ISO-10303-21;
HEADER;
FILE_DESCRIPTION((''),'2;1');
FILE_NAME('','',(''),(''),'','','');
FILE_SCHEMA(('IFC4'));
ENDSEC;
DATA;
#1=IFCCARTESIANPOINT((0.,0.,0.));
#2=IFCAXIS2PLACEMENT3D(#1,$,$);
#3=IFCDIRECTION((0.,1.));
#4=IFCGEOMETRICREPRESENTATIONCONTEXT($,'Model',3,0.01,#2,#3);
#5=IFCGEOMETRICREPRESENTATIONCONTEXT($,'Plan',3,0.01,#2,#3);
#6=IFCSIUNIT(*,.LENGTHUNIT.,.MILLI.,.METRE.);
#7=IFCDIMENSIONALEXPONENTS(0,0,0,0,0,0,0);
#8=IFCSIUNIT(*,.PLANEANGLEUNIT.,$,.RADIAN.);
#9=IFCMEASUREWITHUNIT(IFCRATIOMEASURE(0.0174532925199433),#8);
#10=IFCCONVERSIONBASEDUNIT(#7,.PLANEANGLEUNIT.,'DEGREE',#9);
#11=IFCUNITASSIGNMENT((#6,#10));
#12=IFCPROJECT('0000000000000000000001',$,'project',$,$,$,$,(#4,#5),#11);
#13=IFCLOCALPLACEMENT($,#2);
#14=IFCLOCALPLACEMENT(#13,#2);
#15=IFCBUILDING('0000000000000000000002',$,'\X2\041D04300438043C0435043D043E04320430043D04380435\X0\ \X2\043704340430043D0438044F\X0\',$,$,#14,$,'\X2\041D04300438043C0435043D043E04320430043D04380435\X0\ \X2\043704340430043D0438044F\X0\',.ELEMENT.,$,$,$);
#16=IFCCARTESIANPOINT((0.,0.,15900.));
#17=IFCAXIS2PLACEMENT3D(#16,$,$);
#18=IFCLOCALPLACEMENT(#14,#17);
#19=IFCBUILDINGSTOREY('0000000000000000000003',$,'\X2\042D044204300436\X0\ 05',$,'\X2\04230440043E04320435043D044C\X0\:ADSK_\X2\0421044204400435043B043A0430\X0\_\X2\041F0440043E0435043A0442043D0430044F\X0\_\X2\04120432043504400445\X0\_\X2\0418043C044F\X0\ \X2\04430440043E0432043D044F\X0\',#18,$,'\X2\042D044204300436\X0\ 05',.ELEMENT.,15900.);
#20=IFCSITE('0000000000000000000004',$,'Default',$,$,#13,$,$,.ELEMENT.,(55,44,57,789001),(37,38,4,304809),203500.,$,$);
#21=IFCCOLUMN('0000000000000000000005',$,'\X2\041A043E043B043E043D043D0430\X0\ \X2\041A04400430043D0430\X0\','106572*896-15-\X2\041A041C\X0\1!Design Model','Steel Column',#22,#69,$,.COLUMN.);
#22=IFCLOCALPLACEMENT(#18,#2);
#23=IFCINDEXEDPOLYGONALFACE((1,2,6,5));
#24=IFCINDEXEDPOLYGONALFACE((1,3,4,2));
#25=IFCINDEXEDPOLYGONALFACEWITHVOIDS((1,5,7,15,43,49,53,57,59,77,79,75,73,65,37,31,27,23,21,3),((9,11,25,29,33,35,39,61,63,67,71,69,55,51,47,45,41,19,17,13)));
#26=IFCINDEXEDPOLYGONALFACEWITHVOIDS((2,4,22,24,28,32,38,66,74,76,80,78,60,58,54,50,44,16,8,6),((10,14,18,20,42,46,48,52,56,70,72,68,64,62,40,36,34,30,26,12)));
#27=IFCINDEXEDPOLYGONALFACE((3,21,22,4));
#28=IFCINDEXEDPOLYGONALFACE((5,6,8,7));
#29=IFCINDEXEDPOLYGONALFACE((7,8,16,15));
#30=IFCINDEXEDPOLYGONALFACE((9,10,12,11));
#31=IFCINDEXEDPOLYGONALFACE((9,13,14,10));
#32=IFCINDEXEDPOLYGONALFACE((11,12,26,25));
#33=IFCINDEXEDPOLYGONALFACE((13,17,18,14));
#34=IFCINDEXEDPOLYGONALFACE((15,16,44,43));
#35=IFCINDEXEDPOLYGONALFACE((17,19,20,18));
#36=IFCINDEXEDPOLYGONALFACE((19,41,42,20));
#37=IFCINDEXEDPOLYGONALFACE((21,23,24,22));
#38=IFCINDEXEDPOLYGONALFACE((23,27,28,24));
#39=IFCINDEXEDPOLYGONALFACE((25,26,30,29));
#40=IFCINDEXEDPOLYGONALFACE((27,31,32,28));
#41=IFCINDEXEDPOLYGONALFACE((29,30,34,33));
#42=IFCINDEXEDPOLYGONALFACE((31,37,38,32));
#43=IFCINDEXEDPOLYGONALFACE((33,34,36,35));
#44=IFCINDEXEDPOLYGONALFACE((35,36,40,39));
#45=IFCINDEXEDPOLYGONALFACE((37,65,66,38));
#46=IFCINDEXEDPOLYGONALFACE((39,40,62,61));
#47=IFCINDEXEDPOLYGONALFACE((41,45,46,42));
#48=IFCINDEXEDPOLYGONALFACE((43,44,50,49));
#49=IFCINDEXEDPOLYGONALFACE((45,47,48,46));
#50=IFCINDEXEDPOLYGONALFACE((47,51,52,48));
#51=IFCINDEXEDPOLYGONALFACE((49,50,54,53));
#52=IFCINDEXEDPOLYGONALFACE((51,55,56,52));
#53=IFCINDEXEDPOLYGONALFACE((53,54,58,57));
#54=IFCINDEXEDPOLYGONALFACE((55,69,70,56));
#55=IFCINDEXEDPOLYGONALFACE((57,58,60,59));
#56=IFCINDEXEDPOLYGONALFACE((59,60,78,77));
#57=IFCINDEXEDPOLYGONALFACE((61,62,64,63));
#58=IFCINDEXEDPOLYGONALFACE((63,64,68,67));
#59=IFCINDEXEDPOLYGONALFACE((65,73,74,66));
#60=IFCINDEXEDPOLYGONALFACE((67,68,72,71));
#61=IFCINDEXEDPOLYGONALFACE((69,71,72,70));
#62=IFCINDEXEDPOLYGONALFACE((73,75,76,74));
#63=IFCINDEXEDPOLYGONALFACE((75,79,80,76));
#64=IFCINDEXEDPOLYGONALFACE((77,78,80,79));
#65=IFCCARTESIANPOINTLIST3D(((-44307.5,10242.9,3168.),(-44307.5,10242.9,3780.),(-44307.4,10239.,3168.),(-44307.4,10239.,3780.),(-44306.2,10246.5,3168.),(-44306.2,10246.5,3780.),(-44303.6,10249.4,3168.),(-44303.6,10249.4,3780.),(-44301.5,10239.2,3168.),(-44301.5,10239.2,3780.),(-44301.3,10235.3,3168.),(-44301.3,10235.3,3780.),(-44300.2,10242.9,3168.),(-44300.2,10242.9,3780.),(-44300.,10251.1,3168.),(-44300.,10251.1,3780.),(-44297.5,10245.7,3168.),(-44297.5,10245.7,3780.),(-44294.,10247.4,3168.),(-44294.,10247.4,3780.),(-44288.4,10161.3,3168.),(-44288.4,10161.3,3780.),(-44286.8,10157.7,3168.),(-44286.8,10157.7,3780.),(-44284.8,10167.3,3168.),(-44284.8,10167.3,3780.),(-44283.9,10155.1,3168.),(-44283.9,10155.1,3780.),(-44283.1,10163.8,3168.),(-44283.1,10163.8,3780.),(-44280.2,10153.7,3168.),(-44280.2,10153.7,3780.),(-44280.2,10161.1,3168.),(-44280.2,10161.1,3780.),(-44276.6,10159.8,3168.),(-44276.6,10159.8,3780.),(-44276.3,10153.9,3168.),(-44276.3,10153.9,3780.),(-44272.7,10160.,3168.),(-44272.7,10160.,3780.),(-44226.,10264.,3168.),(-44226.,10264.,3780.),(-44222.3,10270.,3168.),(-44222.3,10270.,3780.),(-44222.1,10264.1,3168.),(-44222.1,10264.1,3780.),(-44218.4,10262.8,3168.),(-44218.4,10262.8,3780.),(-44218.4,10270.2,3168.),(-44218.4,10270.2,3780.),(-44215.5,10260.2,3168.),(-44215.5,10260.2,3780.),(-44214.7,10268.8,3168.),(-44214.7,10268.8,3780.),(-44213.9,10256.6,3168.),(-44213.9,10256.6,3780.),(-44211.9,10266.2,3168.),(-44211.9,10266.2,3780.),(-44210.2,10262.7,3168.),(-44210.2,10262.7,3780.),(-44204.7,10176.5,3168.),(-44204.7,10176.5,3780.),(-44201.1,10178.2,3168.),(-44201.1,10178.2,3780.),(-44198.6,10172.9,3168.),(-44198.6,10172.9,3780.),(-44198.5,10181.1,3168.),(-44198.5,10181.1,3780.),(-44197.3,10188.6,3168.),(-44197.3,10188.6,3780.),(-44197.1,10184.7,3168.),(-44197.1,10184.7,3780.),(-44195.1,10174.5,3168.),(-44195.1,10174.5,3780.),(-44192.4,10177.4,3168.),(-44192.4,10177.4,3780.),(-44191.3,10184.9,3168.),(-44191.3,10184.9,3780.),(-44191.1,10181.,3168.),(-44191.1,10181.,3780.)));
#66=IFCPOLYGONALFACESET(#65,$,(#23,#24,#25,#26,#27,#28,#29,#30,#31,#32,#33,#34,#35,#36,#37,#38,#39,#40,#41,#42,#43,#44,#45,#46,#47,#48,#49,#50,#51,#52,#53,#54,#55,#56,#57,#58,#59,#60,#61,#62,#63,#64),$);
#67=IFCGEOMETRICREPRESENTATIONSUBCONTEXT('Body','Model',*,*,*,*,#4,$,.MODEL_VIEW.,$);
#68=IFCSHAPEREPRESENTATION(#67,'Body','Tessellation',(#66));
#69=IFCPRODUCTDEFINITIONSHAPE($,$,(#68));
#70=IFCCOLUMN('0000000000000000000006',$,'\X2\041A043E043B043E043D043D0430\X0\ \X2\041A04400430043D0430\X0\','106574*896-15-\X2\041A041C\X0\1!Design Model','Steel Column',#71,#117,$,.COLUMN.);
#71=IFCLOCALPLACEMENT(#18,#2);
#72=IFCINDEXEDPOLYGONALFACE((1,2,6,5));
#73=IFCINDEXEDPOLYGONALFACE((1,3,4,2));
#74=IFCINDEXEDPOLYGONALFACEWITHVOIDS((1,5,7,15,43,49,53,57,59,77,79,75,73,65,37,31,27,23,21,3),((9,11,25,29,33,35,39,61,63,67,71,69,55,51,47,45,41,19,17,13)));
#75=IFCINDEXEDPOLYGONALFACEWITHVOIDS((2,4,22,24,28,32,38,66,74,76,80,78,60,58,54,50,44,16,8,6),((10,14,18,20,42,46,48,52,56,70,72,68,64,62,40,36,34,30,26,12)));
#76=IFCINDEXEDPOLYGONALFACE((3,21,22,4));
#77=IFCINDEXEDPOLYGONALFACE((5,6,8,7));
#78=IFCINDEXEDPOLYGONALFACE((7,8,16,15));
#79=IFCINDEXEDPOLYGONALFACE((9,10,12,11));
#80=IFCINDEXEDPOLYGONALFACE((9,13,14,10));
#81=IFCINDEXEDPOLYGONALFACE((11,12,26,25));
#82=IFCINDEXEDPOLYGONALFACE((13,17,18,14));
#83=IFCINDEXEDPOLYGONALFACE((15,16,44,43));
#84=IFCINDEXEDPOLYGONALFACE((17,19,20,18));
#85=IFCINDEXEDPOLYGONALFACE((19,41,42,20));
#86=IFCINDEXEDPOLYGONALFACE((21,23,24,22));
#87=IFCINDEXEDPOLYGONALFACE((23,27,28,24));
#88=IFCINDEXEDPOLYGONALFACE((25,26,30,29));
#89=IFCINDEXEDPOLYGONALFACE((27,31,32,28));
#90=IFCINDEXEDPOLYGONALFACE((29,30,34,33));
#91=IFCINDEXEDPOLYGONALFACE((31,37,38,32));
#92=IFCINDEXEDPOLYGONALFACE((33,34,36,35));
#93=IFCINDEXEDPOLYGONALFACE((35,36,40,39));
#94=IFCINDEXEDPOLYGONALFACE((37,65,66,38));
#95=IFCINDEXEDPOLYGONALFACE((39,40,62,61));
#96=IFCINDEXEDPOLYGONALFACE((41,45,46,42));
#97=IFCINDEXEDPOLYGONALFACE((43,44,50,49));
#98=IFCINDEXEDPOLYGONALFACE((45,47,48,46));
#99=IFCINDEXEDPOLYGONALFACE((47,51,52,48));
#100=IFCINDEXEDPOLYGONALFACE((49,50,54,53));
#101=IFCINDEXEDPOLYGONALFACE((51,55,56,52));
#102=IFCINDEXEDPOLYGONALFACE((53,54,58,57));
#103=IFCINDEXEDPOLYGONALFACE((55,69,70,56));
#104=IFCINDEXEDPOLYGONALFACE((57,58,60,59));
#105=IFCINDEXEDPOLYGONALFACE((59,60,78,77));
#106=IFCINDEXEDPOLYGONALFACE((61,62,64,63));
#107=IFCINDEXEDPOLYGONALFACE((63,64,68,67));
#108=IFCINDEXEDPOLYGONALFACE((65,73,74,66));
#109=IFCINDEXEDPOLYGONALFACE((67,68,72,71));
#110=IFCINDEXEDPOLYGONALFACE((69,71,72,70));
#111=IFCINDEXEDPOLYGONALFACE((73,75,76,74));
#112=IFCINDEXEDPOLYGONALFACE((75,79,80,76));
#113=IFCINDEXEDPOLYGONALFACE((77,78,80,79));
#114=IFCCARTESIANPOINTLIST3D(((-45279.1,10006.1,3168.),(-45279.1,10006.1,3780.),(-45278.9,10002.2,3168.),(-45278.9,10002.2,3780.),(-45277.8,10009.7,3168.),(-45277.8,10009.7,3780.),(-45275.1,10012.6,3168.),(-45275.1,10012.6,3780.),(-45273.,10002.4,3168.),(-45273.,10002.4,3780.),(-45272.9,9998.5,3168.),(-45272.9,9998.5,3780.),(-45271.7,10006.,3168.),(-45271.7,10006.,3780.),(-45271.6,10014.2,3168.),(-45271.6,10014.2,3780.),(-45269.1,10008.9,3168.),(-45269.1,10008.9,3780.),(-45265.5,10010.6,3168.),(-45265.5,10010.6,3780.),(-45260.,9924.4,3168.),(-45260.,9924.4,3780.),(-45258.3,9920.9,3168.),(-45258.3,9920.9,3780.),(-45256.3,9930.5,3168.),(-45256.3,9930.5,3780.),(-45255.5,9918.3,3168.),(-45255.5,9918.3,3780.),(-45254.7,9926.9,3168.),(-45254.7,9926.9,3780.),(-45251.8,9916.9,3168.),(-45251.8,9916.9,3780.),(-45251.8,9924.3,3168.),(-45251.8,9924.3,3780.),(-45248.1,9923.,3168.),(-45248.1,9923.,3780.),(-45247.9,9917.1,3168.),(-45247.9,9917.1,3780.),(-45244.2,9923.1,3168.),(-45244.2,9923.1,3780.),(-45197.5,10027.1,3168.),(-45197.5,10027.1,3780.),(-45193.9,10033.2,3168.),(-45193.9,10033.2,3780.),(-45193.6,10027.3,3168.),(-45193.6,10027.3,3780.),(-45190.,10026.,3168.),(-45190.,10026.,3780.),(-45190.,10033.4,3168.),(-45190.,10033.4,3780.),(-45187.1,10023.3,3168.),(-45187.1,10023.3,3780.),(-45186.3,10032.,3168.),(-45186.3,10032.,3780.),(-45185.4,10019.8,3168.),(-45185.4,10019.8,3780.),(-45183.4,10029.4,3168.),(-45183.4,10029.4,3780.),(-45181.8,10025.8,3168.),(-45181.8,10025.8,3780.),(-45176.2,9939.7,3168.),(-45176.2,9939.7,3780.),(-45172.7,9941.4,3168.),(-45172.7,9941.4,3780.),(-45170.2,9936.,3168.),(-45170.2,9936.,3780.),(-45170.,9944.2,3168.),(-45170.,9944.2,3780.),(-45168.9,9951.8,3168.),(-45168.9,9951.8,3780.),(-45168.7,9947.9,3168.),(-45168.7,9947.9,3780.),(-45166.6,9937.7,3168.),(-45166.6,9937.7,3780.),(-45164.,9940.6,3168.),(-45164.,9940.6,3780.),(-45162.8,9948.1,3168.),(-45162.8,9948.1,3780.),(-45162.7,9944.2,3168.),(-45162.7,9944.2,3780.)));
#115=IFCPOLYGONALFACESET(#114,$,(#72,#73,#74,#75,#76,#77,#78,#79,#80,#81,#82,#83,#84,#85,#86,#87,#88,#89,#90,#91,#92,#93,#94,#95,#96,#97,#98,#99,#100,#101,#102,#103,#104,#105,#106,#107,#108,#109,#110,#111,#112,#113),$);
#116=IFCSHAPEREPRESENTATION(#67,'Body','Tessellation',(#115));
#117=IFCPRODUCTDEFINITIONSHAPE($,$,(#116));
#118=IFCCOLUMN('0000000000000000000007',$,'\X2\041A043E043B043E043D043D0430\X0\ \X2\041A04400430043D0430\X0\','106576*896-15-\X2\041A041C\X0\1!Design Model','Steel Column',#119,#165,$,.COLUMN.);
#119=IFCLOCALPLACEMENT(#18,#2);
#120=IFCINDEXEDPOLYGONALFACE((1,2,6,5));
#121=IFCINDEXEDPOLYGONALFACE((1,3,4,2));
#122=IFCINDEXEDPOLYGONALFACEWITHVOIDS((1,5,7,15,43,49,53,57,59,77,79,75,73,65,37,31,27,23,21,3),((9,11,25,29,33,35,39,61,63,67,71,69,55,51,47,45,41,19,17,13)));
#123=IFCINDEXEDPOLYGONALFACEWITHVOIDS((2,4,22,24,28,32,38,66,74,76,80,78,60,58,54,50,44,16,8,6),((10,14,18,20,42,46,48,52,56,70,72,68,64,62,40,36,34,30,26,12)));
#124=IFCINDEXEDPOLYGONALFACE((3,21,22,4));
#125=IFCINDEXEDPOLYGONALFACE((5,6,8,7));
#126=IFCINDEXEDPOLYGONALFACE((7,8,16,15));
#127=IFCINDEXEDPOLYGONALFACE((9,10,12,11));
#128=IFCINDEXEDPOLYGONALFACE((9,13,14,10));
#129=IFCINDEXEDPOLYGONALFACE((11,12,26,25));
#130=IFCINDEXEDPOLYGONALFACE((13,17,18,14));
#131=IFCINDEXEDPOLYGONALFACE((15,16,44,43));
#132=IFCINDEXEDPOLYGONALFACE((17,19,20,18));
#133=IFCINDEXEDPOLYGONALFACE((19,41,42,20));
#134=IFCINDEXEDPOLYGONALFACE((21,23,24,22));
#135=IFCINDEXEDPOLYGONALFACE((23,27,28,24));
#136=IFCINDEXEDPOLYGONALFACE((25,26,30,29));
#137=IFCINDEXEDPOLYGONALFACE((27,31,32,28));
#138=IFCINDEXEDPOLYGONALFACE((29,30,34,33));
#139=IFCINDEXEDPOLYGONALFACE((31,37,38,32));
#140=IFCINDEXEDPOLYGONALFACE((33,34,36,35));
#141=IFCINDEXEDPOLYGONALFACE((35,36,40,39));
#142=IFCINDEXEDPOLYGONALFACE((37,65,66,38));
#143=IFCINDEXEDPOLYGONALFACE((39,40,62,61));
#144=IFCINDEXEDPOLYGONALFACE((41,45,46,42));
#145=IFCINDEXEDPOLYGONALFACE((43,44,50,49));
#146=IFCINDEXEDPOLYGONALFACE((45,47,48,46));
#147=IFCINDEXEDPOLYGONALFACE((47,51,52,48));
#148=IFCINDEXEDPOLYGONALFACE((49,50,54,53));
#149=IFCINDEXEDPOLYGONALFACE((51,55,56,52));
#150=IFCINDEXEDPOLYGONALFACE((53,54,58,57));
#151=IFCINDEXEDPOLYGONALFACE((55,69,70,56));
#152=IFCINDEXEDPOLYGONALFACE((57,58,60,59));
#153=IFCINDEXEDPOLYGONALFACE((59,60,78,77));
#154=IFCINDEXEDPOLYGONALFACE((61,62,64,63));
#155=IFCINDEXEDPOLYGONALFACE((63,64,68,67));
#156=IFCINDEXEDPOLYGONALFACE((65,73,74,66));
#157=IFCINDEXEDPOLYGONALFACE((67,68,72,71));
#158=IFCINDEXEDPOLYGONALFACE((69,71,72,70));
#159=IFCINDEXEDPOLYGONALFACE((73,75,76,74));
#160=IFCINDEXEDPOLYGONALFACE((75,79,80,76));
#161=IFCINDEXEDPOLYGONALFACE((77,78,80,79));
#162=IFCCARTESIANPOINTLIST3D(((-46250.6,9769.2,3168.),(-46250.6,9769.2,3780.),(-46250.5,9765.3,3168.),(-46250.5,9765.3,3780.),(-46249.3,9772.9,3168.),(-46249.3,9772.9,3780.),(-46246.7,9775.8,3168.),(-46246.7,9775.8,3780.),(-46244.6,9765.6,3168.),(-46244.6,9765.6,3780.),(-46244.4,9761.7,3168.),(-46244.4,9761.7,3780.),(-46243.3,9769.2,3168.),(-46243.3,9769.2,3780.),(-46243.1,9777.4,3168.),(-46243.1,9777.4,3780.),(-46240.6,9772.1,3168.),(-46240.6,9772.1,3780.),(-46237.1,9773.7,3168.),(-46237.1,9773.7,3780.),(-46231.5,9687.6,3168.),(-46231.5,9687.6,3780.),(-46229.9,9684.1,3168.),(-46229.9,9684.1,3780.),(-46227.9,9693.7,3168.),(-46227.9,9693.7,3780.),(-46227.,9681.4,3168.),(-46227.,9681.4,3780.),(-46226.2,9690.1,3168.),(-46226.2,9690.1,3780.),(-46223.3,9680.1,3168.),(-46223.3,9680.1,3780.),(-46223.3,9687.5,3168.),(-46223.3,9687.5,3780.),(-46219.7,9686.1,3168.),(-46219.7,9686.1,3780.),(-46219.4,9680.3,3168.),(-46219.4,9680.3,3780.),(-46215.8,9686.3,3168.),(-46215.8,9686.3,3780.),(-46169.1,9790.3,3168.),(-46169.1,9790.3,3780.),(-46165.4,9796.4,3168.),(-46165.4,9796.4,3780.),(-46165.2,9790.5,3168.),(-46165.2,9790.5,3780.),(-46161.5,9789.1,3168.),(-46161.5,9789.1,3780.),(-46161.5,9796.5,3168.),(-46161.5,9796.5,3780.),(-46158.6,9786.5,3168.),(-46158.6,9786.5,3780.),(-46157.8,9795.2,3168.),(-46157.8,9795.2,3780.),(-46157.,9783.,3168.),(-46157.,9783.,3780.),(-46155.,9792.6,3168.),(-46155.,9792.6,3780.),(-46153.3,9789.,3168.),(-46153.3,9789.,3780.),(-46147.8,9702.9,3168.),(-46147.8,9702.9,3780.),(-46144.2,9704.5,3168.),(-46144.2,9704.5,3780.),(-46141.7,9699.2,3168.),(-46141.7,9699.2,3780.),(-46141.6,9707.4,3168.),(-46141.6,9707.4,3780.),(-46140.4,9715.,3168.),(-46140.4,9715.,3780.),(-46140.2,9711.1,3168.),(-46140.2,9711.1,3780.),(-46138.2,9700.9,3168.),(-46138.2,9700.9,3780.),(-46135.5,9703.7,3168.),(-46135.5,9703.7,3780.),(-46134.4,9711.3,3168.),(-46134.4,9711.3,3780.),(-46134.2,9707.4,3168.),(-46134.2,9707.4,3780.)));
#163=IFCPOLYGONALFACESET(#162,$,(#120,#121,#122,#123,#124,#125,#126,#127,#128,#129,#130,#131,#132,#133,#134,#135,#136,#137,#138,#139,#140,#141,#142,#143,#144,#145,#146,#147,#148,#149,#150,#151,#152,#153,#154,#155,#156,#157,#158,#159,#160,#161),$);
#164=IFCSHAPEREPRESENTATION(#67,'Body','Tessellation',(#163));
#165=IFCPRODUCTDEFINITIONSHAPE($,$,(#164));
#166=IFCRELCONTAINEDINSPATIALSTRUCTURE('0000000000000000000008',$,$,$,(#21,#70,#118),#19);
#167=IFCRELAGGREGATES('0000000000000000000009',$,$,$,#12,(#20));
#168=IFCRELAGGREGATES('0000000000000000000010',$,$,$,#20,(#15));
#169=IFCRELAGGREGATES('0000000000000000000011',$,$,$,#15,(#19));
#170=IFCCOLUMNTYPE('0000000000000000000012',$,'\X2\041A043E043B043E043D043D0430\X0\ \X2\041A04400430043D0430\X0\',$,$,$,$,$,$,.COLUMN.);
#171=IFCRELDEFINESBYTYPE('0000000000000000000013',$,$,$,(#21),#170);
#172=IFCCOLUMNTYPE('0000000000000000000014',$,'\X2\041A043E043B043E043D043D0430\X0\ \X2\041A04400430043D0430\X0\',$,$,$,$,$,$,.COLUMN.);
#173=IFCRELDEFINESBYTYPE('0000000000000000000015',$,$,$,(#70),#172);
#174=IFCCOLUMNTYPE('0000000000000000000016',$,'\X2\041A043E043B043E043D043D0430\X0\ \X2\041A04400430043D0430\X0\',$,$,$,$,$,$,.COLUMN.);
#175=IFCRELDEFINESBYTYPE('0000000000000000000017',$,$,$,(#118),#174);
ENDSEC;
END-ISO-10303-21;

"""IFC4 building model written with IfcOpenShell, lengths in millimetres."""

from ifc_helpers import new_model, entity, si_unit, converted_unit, direction, frame, origin, place, context, subcontext, project, spatial, indexed_curve, outline, extrude, type_object, element, save


model = new_model("IFC4")

# Units and contexts
model_context = context("Model", 3, precision=0.01, world=origin(), true_north=direction((0.0, 1.0)))
plan_context = context("Plan", 3, precision=0.01, world=origin(), true_north=direction((0.0, 1.0)))
body_context = subcontext(model_context, "Body", "Model", "MODEL_VIEW")
ifc_project = project(units=[si_unit("LENGTHUNIT", "METRE", prefix="MILLI"), converted_unit("PLANEANGLEUNIT", "DEGREE", entity("IfcRatioMeasure", 0.0174532925199433), si_unit("PLANEANGLEUNIT", "RADIAN"), dimensions=[0, 0, 0, 0, 0, 0, 0])], contexts=[model_context, plan_context])

# Site, building, storey
site_placement = place(None, origin())
site = spatial("IfcSite", under=ifc_project, at=site_placement, Name="Default", CompositionType="ELEMENT", RefLatitude=(55, 44, 57, 789001), RefLongitude=(37, 38, 4, 304809), RefElevation=203500.0)
building_placement = place(site_placement, origin())
building = spatial("IfcBuilding", under=site, at=building_placement, Name="Наименование здания", LongName="Наименование здания", CompositionType="ELEMENT")
storey_placement = place(building_placement, frame((0.0, 0.0, 15900.0)))
storey = spatial("IfcBuildingStorey", under=building, at=storey_placement, Name="Этаж 05", ObjectType="Уровень:ADSK_Стрелка_Проектная_Вверх_Имя уровня", LongName="Этаж 05", CompositionType="ELEMENT", Elevation=15900.0)

# Columns
column_type_1 = type_object("IfcColumnType", Name="Колонна Крана", PredefinedType="COLUMN")
column_1_placement = place(storey_placement, origin())
element("IfcColumn", 1, at=column_1_placement, inside=storey, type_object=column_type_1, Name="Колонна Крана", Description="106572*896-15-КМ1!Design Model", ObjectType="Steel Column", PredefinedType="COLUMN", context=body_context, shape_type="SweptSolid", body=[
    extrude(outline(indexed_curve([(29.5, -56.8), (33.4, -56.8), (37.0, -55.3), (39.7, -52.6), (41.2, -49.0), (56.8, 29.5), (56.8, 33.4), (55.3, 37.0), (52.6, 39.7), (49.0, 41.2), (-29.5, 56.8), (-33.4, 56.8), (-37.0, 55.3), (-39.7, 52.6), (-41.2, 49.0), (-56.8, -29.5), (-56.8, -33.4), (-55.3, -37.0), (-52.6, -39.7), (-49.0, -41.2), (29.5, -56.8)], self_intersect=False), holes=[indexed_curve([(-43.1, -37.3), (-46.7, -35.8), (-49.5, -33.1), (-51.0, -29.5), (-51.0, -25.5), (-37.3, 43.1), (-35.8, 46.7), (-33.1, 49.5), (-29.5, 51.0), (-25.5, 51.0), (43.1, 37.3), (46.7, 35.8), (49.5, 33.1), (51.0, 29.5), (51.0, 25.5), (37.3, -43.1), (35.8, -46.7), (33.1, -49.5), (29.5, -51.0), (25.5, -51.0), (-43.1, -37.3)], self_intersect=False)]), frame((-44249.3, 10212.0, 3168.0), z_axis=(0.0, 0.0, 1.0), x_axis=(0.906681, 0.421816, 0.0)), (0.0, 0.0, 1.0), 612.0),
])
column_type_2 = type_object("IfcColumnType", Name="Колонна Крана", PredefinedType="COLUMN")
column_2_placement = place(storey_placement, origin())
element("IfcColumn", 2, at=column_2_placement, inside=storey, type_object=column_type_2, Name="Колонна Крана", Description="106574*896-15-КМ1!Design Model", ObjectType="Steel Column", PredefinedType="COLUMN", context=body_context, shape_type="SweptSolid", body=[
    extrude(outline(indexed_curve([(29.5, -56.8), (33.4, -56.8), (37.0, -55.3), (39.7, -52.6), (41.2, -49.0), (56.8, 29.5), (56.8, 33.4), (55.3, 37.0), (52.6, 39.7), (49.0, 41.2), (-29.5, 56.8), (-33.4, 56.8), (-37.0, 55.3), (-39.7, 52.6), (-41.2, 49.0), (-56.8, -29.5), (-56.8, -33.4), (-55.3, -37.0), (-52.6, -39.7), (-49.0, -41.2), (29.5, -56.8)], self_intersect=False), holes=[indexed_curve([(-43.1, -37.3), (-46.7, -35.8), (-49.5, -33.1), (-51.0, -29.5), (-51.0, -25.5), (-37.3, 43.1), (-35.8, 46.7), (-33.1, 49.5), (-29.5, 51.0), (-25.5, 51.0), (43.1, 37.3), (46.7, 35.8), (49.5, 33.1), (51.0, 29.5), (51.0, 25.5), (37.3, -43.1), (35.8, -46.7), (33.1, -49.5), (29.5, -51.0), (25.5, -51.0), (-43.1, -37.3)], self_intersect=False)]), frame((-45220.9, 9975.1, 3168.0), z_axis=(0.0, 0.0, 1.0), x_axis=(0.906681, 0.421816, 0.0)), (0.0, 0.0, 1.0), 612.0),
])
column_type_3 = type_object("IfcColumnType", Name="Колонна Крана", PredefinedType="COLUMN")
column_3_placement = place(storey_placement, origin())
element("IfcColumn", 3, at=column_3_placement, inside=storey, type_object=column_type_3, Name="Колонна Крана", Description="106576*896-15-КМ1!Design Model", ObjectType="Steel Column", PredefinedType="COLUMN", context=body_context, shape_type="SweptSolid", body=[
    extrude(outline(indexed_curve([(29.5, -56.8), (33.4, -56.8), (37.0, -55.3), (39.7, -52.6), (41.2, -49.0), (56.8, 29.5), (56.8, 33.4), (55.3, 37.0), (52.6, 39.7), (49.0, 41.2), (-29.5, 56.8), (-33.4, 56.8), (-37.0, 55.3), (-39.7, 52.6), (-41.2, 49.0), (-56.8, -29.5), (-56.8, -33.4), (-55.3, -37.0), (-52.6, -39.7), (-49.0, -41.2), (29.5, -56.8)], self_intersect=False), holes=[indexed_curve([(-43.1, -37.3), (-46.7, -35.8), (-49.5, -33.1), (-51.0, -29.5), (-51.0, -25.5), (-37.3, 43.1), (-35.8, 46.7), (-33.1, 49.5), (-29.5, 51.0), (-25.5, 51.0), (43.1, 37.3), (46.7, 35.8), (49.5, 33.1), (51.0, 29.5), (51.0, 25.5), (37.3, -43.1), (35.8, -46.7), (33.1, -49.5), (29.5, -51.0), (25.5, -51.0), (-43.1, -37.3)], self_intersect=False)]), frame((-46192.4, 9738.3, 3168.0), z_axis=(0.0, 0.0, 1.0), x_axis=(0.906681, 0.421816, 0.0)), (0.0, 0.0, 1.0), 612.0),
])

save(model, "model.ifc")
